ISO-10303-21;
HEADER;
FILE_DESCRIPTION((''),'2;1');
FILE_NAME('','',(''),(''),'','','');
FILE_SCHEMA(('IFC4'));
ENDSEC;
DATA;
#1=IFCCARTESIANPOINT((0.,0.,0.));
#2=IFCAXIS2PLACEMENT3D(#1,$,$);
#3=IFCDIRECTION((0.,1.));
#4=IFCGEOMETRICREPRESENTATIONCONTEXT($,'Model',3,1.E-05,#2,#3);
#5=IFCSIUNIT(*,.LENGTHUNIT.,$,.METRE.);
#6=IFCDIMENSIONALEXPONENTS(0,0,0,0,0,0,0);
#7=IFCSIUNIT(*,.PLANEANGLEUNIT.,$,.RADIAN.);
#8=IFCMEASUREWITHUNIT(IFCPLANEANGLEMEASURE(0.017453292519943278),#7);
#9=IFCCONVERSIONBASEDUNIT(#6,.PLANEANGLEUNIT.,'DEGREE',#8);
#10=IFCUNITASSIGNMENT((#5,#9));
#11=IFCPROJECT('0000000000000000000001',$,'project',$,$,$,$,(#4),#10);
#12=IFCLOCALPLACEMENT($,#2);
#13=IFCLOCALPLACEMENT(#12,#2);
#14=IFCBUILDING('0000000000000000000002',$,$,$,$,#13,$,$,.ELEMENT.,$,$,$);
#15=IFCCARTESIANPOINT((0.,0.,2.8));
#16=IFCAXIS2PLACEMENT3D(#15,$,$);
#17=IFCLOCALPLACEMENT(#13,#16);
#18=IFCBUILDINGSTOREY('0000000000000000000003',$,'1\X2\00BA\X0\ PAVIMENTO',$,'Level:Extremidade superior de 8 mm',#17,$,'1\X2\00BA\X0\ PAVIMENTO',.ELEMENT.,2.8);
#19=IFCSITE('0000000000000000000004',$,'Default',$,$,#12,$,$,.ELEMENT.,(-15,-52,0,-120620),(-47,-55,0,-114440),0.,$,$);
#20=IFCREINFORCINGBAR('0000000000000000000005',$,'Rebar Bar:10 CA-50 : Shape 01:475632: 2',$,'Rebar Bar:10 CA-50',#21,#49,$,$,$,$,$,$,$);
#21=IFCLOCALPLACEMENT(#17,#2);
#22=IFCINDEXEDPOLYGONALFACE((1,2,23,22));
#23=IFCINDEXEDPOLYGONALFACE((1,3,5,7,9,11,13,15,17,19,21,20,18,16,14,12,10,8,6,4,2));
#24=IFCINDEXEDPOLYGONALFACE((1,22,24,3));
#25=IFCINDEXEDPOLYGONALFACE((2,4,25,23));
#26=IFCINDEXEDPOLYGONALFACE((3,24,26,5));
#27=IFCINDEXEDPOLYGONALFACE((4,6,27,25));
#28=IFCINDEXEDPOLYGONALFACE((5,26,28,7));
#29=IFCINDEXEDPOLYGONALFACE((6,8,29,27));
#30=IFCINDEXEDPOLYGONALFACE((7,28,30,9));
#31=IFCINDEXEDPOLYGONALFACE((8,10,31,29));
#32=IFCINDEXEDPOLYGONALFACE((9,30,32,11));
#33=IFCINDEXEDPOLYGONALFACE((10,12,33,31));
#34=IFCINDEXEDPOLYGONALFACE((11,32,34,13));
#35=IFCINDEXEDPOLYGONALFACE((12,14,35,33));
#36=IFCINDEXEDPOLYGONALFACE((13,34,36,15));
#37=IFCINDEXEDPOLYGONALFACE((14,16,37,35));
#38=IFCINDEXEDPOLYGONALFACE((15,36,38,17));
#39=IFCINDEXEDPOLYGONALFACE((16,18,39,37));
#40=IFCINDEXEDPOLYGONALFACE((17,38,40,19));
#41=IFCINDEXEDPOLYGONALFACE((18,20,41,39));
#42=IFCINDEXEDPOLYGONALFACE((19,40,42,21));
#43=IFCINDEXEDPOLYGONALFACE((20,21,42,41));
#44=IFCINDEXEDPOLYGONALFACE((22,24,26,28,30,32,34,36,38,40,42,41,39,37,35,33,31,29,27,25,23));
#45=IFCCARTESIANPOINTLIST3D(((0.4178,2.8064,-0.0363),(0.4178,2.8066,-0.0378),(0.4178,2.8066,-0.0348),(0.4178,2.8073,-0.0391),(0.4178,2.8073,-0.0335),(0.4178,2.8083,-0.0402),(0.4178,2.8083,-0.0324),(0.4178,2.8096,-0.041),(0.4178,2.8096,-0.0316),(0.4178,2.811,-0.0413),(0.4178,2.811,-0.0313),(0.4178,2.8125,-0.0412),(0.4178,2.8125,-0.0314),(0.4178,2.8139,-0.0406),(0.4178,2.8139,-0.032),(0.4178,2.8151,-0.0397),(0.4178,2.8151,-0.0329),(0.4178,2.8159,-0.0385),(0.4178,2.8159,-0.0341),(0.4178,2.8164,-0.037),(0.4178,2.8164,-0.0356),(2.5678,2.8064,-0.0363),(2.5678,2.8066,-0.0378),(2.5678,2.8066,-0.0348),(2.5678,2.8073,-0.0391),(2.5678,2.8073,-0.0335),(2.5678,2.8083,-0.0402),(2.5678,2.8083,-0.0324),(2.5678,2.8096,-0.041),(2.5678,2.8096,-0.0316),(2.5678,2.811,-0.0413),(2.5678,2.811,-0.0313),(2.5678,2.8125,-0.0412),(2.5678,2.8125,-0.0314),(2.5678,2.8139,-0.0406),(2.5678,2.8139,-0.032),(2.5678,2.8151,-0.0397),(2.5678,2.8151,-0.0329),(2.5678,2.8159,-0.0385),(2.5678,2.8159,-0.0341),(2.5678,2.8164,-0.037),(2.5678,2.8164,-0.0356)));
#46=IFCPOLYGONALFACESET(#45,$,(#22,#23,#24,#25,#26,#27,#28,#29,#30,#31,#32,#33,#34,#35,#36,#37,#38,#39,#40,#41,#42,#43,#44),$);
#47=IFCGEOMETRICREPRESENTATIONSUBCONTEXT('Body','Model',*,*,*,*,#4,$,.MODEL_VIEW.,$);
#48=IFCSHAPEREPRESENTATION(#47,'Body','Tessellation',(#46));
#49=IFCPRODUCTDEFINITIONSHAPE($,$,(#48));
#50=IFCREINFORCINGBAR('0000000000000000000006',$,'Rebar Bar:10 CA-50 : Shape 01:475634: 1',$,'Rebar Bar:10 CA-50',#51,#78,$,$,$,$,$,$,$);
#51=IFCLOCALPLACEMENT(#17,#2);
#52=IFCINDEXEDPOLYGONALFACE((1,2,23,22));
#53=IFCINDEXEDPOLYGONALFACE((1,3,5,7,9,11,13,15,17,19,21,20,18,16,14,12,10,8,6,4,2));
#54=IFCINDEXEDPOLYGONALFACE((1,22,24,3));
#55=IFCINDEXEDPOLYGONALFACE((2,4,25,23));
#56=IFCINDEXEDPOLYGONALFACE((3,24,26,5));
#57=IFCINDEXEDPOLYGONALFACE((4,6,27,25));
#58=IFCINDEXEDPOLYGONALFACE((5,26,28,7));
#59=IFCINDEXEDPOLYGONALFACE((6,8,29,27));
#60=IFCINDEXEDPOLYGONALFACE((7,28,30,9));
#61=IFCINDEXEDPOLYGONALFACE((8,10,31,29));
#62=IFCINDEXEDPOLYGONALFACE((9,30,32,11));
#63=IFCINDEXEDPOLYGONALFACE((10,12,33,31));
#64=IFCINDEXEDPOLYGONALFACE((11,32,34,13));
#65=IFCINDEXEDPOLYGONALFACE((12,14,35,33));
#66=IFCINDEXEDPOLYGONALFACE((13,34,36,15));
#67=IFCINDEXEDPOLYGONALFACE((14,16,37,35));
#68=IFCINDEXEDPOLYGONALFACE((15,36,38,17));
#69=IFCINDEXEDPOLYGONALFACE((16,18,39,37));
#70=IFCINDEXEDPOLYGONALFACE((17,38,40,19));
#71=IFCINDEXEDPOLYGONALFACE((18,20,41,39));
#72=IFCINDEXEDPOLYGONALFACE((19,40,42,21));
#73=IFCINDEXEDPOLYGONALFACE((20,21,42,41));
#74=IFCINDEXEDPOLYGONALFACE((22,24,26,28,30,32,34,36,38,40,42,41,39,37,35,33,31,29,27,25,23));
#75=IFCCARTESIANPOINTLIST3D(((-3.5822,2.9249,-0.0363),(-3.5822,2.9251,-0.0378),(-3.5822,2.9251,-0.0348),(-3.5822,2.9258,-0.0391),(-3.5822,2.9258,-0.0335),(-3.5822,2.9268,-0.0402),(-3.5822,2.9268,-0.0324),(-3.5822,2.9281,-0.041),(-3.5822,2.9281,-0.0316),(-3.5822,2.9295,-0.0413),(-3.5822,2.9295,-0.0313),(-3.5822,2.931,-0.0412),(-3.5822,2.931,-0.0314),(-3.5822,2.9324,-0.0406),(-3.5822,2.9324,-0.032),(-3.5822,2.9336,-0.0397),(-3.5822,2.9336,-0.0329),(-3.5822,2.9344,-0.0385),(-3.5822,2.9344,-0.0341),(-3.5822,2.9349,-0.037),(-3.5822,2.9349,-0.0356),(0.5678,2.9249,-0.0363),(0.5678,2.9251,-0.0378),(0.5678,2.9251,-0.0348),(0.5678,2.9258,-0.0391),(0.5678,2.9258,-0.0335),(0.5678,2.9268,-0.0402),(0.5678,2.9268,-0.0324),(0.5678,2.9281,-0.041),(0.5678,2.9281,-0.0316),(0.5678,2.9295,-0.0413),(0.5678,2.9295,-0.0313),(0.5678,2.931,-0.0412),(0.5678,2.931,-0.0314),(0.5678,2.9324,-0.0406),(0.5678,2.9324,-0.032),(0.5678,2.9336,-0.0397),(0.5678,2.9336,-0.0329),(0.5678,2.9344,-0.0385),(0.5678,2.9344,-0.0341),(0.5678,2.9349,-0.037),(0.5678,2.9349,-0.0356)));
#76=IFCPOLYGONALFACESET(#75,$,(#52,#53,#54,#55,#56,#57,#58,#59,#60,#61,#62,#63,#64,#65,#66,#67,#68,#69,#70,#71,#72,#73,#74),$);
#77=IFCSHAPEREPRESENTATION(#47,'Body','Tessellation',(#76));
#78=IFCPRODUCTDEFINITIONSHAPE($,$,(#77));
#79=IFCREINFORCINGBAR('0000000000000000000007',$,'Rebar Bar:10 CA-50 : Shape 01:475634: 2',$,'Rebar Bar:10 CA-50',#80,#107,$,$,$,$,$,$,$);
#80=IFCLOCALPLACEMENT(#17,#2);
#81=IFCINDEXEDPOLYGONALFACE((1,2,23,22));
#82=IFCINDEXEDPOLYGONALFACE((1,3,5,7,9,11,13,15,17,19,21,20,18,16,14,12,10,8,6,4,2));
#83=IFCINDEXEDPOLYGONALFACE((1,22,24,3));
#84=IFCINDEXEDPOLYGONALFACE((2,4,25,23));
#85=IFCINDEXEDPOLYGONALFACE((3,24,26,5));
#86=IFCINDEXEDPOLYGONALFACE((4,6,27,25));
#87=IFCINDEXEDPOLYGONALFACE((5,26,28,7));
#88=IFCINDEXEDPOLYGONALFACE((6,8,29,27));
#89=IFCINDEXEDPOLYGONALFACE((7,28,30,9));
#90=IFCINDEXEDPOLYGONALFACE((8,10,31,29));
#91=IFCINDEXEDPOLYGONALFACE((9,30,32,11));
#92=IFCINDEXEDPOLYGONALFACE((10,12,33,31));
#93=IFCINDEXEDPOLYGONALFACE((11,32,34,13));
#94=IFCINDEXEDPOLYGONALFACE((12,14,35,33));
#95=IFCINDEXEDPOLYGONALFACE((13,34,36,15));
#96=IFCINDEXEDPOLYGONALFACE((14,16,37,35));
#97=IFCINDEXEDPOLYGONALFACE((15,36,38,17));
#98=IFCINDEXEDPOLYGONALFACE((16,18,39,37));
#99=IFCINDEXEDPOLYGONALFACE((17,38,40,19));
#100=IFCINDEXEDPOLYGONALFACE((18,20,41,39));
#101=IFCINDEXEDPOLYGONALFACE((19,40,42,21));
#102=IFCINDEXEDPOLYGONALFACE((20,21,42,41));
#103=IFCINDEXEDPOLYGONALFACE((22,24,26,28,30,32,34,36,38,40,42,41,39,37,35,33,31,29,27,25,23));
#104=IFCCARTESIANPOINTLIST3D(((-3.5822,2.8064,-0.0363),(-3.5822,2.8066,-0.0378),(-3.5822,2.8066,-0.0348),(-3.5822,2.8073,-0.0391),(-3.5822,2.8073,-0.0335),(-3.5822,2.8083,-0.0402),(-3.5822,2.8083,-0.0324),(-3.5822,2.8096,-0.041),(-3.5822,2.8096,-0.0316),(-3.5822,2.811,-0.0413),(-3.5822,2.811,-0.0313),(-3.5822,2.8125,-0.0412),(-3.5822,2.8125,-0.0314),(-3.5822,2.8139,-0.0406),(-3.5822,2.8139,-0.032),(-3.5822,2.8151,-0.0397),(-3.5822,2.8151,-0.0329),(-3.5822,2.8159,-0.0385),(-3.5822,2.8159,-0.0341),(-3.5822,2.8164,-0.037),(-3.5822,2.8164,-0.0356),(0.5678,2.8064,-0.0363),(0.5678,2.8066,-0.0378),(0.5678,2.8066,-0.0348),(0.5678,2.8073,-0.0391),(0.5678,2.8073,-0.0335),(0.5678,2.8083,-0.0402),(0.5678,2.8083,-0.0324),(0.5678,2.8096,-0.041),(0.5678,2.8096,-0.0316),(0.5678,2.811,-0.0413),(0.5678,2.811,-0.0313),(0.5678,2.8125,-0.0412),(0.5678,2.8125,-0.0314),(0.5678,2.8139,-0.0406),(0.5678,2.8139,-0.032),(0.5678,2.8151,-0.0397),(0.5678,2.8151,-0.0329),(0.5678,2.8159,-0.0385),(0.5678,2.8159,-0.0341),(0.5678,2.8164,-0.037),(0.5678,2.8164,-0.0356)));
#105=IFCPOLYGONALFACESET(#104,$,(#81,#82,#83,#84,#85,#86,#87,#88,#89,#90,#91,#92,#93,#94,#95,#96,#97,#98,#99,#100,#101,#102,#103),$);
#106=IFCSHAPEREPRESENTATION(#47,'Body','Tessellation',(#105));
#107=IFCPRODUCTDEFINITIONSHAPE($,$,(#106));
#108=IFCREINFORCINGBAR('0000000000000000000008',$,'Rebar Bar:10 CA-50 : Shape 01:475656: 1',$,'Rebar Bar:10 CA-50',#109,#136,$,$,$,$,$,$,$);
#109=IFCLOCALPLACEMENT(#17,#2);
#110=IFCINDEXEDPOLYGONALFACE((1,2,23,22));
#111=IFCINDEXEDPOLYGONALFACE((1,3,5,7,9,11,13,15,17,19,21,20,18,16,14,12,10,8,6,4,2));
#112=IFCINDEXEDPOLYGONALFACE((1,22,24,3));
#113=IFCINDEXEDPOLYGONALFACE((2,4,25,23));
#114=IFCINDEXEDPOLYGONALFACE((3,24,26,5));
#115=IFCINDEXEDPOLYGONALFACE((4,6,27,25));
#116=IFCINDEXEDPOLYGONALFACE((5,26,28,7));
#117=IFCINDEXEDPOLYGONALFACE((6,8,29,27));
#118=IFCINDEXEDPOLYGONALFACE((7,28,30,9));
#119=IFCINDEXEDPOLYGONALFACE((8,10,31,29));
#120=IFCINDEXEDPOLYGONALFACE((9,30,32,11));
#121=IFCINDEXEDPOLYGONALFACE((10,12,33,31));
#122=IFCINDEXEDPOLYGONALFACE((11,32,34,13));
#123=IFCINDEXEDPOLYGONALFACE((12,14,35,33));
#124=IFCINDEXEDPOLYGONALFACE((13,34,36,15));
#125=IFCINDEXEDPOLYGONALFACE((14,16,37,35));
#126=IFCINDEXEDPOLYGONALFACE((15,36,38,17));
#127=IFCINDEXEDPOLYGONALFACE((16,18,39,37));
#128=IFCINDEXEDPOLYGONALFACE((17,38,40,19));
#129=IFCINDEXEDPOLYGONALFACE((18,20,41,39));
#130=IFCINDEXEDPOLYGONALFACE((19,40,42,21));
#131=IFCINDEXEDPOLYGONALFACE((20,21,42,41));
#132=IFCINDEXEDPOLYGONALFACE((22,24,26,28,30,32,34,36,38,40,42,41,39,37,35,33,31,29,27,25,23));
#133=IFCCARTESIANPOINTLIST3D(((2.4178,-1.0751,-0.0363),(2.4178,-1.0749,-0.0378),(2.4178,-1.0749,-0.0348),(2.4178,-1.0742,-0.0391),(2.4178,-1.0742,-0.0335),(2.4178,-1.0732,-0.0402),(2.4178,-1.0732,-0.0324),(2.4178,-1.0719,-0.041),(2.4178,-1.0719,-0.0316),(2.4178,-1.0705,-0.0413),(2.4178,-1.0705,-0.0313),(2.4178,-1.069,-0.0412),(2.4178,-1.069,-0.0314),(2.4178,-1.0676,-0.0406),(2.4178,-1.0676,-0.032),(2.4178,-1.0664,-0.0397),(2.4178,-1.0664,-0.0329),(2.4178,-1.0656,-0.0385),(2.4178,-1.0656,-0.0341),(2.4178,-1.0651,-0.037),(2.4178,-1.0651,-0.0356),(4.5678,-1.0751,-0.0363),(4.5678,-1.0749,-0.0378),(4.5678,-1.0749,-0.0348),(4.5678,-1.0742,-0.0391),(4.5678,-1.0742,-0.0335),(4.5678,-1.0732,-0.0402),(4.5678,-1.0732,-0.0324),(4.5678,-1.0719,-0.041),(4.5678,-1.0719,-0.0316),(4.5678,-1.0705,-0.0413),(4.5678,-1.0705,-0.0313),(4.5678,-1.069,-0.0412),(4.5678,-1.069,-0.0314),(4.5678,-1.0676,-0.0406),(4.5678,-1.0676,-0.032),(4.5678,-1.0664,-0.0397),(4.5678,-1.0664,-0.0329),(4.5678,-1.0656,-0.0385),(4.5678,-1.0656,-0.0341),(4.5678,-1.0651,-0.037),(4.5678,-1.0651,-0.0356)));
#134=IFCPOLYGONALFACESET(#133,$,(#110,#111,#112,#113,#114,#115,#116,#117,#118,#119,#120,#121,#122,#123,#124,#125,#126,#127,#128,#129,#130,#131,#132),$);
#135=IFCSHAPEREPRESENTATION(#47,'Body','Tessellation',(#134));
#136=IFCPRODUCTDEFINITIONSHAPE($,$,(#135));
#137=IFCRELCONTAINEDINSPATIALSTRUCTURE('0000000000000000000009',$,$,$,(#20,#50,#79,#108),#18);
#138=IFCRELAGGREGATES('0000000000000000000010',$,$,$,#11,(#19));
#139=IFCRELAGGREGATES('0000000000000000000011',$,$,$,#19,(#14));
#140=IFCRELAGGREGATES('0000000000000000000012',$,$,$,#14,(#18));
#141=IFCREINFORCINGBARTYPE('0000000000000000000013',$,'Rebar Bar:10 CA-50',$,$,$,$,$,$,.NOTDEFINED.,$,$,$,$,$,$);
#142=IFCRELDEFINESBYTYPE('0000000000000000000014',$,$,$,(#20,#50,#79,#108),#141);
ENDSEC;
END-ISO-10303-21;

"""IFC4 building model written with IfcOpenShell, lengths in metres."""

from ifc_helpers import new_model, entity, si_unit, converted_unit, direction, frame, origin, place, context, subcontext, project, spatial, type_object, element, save


model = new_model("IFC4")

# Units and contexts
model_context = context("Model", 3, precision=1e-05, world=origin(), true_north=direction((0.0, 1.0)))
body_context = subcontext(model_context, "Body", "Model", "MODEL_VIEW")
ifc_project = project(units=[si_unit("LENGTHUNIT", "METRE"), converted_unit("PLANEANGLEUNIT", "DEGREE", entity("IfcPlaneAngleMeasure", 0.017453292519943278), si_unit("PLANEANGLEUNIT", "RADIAN"), dimensions=[0, 0, 0, 0, 0, 0, 0])], contexts=[model_context])

# Site, building, storey
site_placement = place(None, origin())
site = spatial("IfcSite", under=ifc_project, at=site_placement, Name="Default", CompositionType="ELEMENT", RefLatitude=(-15, -52, 0, -120620), RefLongitude=(-47, -55, 0, -114440), RefElevation=0.0)
building_placement = place(site_placement, origin())
building = spatial("IfcBuilding", under=site, at=building_placement, CompositionType="ELEMENT")
storey_placement = place(building_placement, frame((0.0, 0.0, 2.8)))
storey = spatial("IfcBuildingStorey", under=building, at=storey_placement, Name="1º PAVIMENTO", ObjectType="Level:Extremidade superior de 8 mm", LongName="1º PAVIMENTO", CompositionType="ELEMENT", Elevation=2.8)

# Reinforcing bars
reinforcing_bar_type = type_object("IfcReinforcingBarType", Name="Rebar Bar:10 CA-50", PredefinedType="NOTDEFINED")
reinforcing_bar_1_placement = place(storey_placement, origin())
element("IfcReinforcingBar", 1, at=reinforcing_bar_1_placement, inside=storey, type_object=reinforcing_bar_type, Name="Rebar Bar:10 CA-50 : Shape 01:475632: 2", ObjectType="Rebar Bar:10 CA-50", context=body_context, shape_type="AdvancedSweptSolid", body=[
    entity("IfcSweptDiskSolid", entity("IfcIndexedPolyCurve", entity("IfcCartesianPointList3D", [[2.5678, 2.8114, -0.0363], [0.4178, 2.8114, -0.0363]]), None, False), 0.005, None, 0.0, 1.0),
])
reinforcing_bar_2_placement = place(storey_placement, origin())
element("IfcReinforcingBar", 2, at=reinforcing_bar_2_placement, inside=storey, type_object=reinforcing_bar_type, Name="Rebar Bar:10 CA-50 : Shape 01:475634: 1", ObjectType="Rebar Bar:10 CA-50", context=body_context, shape_type="AdvancedSweptSolid", body=[
    entity("IfcSweptDiskSolid", entity("IfcIndexedPolyCurve", entity("IfcCartesianPointList3D", [[0.5678, 2.9299, -0.0363], [-3.5822, 2.9299, -0.0363]]), None, False), 0.005, None, 0.0, 1.0),
])
reinforcing_bar_3_placement = place(storey_placement, origin())
element("IfcReinforcingBar", 3, at=reinforcing_bar_3_placement, inside=storey, type_object=reinforcing_bar_type, Name="Rebar Bar:10 CA-50 : Shape 01:475634: 2", ObjectType="Rebar Bar:10 CA-50", context=body_context, shape_type="AdvancedSweptSolid", body=[
    entity("IfcSweptDiskSolid", entity("IfcIndexedPolyCurve", entity("IfcCartesianPointList3D", [[0.5678, 2.8114, -0.0363], [-3.5822, 2.8114, -0.0363]]), None, False), 0.005, None, 0.0, 1.0),
])
reinforcing_bar_4_placement = place(storey_placement, origin())
element("IfcReinforcingBar", 4, at=reinforcing_bar_4_placement, inside=storey, type_object=reinforcing_bar_type, Name="Rebar Bar:10 CA-50 : Shape 01:475656: 1", ObjectType="Rebar Bar:10 CA-50", context=body_context, shape_type="AdvancedSweptSolid", body=[
    entity("IfcSweptDiskSolid", entity("IfcIndexedPolyCurve", entity("IfcCartesianPointList3D", [[4.5678, -1.0701, -0.0363], [2.4178, -1.0701, -0.0363]]), None, False), 0.005, None, 0.0, 1.0),
])

save(model, "model.ifc")
